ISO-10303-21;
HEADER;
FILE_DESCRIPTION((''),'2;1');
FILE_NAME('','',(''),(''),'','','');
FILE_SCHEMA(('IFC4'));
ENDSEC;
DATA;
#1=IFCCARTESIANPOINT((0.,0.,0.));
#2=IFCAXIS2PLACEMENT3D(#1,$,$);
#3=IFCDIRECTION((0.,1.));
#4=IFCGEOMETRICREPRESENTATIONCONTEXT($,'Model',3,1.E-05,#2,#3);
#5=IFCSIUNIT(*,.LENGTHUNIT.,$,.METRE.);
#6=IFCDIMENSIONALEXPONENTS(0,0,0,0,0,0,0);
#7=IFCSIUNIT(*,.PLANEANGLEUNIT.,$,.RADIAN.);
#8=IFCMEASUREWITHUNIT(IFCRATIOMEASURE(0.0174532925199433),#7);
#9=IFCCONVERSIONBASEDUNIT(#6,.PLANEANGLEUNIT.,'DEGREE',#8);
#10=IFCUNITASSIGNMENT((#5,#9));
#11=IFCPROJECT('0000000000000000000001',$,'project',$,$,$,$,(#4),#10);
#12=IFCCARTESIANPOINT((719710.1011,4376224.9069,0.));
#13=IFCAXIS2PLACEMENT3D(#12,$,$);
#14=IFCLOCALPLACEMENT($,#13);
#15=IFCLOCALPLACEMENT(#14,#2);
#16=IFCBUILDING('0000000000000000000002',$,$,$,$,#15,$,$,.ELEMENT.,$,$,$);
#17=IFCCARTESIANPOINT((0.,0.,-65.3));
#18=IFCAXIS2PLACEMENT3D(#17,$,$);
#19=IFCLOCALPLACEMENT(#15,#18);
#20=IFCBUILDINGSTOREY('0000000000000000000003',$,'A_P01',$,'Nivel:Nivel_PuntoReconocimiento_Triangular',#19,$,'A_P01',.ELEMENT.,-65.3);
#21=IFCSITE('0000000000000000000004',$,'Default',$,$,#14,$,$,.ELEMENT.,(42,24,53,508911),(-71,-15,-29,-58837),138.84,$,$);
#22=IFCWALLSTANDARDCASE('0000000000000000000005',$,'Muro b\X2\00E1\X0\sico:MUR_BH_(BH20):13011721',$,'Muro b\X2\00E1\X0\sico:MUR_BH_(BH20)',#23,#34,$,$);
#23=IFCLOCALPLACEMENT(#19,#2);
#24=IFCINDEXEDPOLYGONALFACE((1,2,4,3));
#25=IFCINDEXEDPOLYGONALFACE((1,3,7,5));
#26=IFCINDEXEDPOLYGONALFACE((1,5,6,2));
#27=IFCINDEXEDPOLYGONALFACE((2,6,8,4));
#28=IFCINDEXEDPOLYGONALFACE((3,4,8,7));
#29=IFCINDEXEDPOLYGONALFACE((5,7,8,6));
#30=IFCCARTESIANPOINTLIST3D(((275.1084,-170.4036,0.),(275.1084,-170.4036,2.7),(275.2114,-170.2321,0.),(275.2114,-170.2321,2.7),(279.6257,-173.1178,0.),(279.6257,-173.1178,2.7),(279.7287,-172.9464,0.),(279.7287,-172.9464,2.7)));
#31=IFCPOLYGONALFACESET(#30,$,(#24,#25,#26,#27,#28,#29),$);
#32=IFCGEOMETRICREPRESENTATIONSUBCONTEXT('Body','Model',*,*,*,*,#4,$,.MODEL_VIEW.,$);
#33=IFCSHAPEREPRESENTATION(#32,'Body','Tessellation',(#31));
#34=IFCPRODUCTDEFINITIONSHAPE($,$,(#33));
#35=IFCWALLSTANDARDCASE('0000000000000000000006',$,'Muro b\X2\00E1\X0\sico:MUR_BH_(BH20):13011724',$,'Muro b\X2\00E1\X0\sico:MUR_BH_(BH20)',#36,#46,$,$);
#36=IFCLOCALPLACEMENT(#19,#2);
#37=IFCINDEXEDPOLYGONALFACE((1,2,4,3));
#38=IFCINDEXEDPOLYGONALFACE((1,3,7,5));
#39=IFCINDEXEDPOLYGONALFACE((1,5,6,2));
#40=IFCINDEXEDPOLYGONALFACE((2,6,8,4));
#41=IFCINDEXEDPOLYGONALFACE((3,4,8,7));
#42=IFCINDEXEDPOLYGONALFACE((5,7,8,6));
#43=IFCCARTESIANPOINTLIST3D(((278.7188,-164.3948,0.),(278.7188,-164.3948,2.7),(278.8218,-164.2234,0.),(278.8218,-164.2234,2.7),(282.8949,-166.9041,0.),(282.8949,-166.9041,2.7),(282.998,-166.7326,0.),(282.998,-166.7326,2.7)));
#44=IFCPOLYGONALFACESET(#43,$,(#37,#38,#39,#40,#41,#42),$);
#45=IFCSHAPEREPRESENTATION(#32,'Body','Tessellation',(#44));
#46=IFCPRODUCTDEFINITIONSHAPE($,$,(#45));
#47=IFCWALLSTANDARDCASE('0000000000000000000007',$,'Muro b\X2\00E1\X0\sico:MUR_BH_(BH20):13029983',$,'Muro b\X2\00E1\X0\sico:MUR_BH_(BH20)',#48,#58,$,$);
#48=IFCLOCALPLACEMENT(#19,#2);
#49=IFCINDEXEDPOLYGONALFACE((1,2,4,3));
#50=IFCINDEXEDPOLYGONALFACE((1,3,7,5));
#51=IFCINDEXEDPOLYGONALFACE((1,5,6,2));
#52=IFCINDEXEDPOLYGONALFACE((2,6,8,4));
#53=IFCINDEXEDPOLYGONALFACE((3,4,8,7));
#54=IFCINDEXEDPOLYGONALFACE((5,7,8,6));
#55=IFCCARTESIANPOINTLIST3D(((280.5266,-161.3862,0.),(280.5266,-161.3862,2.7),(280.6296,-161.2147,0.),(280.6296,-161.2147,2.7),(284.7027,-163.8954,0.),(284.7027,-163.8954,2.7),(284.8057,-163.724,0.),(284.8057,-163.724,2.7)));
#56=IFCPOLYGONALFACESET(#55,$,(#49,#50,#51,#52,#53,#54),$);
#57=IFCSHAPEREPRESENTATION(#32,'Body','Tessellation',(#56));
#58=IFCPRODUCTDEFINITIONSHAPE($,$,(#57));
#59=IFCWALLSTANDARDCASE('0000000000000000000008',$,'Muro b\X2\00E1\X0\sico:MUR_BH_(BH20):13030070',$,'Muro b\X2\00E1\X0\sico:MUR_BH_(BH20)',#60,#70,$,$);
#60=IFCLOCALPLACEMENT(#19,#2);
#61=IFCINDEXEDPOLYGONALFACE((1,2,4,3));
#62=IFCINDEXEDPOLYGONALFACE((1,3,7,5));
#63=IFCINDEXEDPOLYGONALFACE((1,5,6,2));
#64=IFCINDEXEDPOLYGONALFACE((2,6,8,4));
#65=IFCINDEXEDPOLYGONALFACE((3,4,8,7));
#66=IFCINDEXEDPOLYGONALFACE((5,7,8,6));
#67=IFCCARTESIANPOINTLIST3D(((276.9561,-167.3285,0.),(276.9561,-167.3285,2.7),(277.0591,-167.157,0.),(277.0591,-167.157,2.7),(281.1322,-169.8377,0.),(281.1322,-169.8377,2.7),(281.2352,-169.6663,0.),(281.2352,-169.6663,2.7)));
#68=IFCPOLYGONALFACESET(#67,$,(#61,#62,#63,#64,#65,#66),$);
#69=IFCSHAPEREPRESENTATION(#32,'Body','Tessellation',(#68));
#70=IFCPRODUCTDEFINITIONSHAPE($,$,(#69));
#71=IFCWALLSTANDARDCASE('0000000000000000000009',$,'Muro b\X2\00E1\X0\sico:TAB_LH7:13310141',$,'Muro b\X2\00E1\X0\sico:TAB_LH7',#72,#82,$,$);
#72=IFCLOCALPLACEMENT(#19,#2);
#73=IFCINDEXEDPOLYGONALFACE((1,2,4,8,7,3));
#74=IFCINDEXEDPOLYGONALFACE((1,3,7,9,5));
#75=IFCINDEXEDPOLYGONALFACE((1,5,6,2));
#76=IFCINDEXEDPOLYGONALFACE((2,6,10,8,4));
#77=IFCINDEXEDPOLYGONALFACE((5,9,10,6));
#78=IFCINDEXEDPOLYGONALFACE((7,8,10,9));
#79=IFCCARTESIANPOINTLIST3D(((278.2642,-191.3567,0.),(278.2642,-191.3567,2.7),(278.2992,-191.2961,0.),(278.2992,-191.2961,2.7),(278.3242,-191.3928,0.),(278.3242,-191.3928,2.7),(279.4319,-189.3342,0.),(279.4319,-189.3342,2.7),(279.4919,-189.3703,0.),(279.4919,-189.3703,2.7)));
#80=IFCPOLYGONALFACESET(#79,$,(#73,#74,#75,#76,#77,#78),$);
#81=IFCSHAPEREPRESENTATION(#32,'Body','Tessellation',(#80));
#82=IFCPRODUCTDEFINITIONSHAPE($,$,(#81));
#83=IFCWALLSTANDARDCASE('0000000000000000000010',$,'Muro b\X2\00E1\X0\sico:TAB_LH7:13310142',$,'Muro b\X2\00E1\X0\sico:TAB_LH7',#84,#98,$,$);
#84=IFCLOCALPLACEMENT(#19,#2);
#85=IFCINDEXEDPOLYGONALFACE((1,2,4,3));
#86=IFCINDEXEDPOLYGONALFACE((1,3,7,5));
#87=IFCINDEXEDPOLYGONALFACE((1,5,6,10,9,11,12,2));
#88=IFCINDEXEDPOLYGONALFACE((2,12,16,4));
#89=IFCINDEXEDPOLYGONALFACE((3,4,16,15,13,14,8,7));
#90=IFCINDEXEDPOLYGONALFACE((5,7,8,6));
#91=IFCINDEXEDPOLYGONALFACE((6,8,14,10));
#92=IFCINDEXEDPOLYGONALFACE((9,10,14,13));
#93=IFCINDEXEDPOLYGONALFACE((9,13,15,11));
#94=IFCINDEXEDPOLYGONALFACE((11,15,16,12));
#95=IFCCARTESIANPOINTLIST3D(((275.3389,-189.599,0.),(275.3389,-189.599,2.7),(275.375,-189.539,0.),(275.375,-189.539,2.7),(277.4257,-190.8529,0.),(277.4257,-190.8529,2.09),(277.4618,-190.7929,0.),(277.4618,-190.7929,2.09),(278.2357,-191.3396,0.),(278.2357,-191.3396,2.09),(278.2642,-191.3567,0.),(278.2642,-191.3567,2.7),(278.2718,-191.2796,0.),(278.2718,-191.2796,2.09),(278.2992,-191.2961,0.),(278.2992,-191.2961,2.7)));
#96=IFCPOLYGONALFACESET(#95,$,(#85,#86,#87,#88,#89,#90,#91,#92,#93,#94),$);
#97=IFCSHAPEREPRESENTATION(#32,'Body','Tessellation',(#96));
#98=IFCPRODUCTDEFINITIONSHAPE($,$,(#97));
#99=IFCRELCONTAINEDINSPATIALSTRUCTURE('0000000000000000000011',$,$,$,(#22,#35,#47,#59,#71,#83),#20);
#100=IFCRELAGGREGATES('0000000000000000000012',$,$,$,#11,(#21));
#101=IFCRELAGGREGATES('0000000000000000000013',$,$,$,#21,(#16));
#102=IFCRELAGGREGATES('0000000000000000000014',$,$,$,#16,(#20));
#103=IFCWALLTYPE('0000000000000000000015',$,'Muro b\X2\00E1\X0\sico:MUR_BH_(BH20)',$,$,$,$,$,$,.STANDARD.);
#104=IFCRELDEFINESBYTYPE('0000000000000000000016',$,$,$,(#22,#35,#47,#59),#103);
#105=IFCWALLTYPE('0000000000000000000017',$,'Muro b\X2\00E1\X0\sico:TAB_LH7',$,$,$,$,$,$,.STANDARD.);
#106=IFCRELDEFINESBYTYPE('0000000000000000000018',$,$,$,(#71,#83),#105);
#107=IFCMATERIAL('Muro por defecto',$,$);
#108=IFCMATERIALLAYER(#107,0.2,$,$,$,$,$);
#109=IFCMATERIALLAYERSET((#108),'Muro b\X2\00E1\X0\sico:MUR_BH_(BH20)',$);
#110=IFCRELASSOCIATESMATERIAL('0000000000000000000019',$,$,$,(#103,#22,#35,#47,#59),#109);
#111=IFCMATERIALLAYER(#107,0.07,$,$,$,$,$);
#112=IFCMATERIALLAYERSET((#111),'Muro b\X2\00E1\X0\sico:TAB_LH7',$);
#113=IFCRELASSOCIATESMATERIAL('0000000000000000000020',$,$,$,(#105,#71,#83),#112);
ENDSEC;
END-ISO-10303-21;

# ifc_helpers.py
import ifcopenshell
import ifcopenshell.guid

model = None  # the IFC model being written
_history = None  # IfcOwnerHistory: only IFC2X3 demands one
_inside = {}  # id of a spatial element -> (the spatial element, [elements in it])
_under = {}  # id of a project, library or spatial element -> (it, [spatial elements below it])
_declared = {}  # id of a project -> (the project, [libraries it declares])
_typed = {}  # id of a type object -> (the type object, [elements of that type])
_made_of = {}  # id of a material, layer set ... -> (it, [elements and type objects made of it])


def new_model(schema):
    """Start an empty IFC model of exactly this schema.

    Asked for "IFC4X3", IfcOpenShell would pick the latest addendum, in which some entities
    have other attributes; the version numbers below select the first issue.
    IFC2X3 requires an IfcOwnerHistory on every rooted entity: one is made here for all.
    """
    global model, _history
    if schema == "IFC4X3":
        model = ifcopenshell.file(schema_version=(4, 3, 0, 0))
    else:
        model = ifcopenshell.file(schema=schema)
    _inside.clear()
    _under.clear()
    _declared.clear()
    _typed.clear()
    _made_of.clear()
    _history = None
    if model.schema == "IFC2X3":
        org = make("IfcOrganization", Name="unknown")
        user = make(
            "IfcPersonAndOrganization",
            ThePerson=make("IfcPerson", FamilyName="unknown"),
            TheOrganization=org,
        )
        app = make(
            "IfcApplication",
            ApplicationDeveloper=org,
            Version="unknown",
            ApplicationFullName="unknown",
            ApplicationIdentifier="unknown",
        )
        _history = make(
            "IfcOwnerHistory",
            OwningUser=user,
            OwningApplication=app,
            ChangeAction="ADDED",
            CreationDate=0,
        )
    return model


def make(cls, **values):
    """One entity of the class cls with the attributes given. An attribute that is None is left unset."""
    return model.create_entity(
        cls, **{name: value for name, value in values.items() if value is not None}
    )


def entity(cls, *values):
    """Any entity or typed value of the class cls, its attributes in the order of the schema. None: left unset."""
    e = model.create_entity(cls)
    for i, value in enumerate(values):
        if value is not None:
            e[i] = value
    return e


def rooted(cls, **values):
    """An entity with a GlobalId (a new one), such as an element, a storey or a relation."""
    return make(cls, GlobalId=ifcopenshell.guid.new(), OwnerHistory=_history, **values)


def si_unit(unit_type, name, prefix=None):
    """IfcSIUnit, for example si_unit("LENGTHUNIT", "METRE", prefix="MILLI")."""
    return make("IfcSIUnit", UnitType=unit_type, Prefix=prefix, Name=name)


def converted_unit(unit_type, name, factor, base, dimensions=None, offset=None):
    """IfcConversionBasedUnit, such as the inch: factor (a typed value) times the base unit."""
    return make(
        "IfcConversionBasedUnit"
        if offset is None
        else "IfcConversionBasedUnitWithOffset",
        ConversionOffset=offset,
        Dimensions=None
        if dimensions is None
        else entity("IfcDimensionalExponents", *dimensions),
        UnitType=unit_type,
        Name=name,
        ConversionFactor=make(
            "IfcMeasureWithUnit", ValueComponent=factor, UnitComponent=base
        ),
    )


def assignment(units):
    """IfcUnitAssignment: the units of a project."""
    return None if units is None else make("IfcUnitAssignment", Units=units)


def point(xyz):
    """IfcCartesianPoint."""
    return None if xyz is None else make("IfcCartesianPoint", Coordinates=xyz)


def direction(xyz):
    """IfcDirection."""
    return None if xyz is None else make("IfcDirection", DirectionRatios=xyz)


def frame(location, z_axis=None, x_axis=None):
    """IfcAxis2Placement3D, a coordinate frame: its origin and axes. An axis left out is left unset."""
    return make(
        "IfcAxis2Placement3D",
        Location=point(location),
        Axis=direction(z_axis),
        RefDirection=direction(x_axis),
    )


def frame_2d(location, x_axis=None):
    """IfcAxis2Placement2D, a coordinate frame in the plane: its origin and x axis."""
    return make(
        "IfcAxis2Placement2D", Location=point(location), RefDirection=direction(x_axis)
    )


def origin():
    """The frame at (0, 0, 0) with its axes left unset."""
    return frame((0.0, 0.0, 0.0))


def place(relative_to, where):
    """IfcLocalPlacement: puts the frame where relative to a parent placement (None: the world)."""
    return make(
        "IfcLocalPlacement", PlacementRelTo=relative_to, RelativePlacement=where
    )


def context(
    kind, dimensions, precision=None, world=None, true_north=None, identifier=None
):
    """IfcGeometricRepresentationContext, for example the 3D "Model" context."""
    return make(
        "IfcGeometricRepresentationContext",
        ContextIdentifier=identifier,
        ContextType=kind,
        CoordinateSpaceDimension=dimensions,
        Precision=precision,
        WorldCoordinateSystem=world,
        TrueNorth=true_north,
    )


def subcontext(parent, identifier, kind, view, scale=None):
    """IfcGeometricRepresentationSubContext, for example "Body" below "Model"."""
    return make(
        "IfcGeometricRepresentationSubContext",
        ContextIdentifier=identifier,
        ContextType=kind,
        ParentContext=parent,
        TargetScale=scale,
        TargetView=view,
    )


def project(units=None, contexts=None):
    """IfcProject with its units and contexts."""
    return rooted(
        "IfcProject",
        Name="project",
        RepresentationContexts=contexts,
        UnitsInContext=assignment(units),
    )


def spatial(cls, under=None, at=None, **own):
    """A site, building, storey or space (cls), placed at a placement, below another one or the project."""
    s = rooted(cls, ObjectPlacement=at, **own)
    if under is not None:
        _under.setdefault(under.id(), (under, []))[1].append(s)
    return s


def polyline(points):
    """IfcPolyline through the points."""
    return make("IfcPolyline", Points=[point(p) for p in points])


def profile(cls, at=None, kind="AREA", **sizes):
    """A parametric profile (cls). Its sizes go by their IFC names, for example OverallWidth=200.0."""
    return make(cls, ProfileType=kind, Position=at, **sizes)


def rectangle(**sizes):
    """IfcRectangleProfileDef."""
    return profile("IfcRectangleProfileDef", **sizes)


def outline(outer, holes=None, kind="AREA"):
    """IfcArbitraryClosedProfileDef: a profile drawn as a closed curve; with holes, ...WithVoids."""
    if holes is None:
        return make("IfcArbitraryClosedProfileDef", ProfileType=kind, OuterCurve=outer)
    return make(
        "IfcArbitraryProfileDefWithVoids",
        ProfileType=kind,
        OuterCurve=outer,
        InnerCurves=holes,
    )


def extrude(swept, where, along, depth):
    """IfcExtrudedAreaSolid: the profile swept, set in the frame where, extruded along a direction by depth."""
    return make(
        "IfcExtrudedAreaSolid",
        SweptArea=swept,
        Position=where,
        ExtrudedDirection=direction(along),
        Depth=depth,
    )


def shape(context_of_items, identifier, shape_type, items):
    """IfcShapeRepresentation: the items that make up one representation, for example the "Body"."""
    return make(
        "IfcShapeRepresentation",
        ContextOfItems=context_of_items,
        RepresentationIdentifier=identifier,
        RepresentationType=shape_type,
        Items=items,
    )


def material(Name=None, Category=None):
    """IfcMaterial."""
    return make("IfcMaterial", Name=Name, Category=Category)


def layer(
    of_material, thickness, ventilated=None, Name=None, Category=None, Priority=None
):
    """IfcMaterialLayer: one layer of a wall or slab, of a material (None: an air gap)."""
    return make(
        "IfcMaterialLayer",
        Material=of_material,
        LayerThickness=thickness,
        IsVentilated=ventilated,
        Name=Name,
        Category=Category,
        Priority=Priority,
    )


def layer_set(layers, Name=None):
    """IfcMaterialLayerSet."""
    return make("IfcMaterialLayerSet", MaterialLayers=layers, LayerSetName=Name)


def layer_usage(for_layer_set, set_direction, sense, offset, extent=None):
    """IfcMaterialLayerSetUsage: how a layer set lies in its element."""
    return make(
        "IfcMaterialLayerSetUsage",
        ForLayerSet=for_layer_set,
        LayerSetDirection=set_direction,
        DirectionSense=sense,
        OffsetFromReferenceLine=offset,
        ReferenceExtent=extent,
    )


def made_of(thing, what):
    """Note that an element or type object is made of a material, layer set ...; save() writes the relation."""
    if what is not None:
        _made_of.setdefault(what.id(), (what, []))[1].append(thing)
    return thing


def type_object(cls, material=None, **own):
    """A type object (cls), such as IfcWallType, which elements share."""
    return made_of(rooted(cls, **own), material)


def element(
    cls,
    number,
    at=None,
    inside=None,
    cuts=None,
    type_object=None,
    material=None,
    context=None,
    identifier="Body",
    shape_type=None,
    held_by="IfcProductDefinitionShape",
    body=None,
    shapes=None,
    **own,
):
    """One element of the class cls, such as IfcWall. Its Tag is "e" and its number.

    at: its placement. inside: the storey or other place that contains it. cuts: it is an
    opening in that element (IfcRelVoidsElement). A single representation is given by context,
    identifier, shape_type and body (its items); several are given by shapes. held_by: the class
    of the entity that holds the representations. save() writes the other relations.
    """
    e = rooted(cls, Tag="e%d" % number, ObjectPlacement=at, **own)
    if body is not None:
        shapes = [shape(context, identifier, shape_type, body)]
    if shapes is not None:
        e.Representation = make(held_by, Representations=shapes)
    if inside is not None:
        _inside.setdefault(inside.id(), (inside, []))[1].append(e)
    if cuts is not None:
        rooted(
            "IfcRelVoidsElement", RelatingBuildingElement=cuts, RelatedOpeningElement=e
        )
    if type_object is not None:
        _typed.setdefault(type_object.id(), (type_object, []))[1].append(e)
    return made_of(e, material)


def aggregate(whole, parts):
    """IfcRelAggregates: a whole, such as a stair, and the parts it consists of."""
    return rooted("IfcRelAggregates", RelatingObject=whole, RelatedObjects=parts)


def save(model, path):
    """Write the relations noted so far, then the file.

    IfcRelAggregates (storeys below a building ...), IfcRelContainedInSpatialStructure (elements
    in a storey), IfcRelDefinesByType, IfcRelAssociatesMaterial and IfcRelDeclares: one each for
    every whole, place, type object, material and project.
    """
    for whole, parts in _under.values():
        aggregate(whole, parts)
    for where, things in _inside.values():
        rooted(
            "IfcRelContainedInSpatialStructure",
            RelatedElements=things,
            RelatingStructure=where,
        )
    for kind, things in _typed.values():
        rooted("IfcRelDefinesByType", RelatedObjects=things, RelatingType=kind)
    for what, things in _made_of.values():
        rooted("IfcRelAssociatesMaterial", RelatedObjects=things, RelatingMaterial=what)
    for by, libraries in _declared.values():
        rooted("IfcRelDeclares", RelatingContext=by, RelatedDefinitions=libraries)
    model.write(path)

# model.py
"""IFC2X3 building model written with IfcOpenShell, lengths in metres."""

from ifc_helpers import new_model, entity, si_unit, converted_unit, direction, frame, frame_2d, origin, place, context, subcontext, project, spatial, polyline, rectangle, outline, extrude, material, layer, layer_set, layer_usage, type_object, element, save


model = new_model("IFC2X3")

# Units and contexts
model_context = context("Model", 3, precision=1e-05, world=origin(), true_north=direction((0.0, 1.0)))
body_context = subcontext(model_context, "Body", "Model", "MODEL_VIEW")
ifc_project = project(units=[si_unit("LENGTHUNIT", "METRE"), converted_unit("PLANEANGLEUNIT", "DEGREE", entity("IfcRatioMeasure", 0.0174532925199433), si_unit("PLANEANGLEUNIT", "RADIAN"), dimensions=[0, 0, 0, 0, 0, 0, 0])], contexts=[model_context])

# Site, building, storey
site_placement = place(None, frame((719710.1011, 4376224.9069, 0.0)))
site = spatial("IfcSite", under=ifc_project, at=site_placement, Name="Default", CompositionType="ELEMENT", RefLatitude=(42, 24, 53, 508911), RefLongitude=(-71, -15, -29, -58837), RefElevation=138.84)
building_placement = place(site_placement, origin())
building = spatial("IfcBuilding", under=site, at=building_placement, CompositionType="ELEMENT")
storey_placement = place(building_placement, frame((0.0, 0.0, -65.3)))
storey = spatial("IfcBuildingStorey", under=building, at=storey_placement, Name="A_P01", ObjectType="Nivel:Nivel_PuntoReconocimiento_Triangular", LongName="A_P01", CompositionType="ELEMENT", Elevation=-65.3)

# Walls
ifc_material_1 = material(Name="Muro por defecto")
ifc_layer_1 = layer(ifc_material_1, 0.2)
ifc_layer_set_1 = layer_set([ifc_layer_1], Name="Muro básico:MUR_BH_(BH20)")
wall_type_1 = type_object("IfcWallType", Name="Muro básico:MUR_BH_(BH20)", PredefinedType="STANDARD", material=ifc_layer_set_1)
ifc_layer_usage_1 = layer_usage(ifc_layer_set_1, "AXIS2", "NEGATIVE", 0.1)
wall_1_placement = place(storey_placement, frame((279.6772, -173.0321, 0.0), z_axis=(0.0, 0.0, 1.0), x_axis=(-0.857167, 0.515038, 0.0)))
element("IfcWallStandardCase", 1, at=wall_1_placement, inside=storey, type_object=wall_type_1, material=ifc_layer_usage_1, Name="Muro básico:MUR_BH_(BH20):13011721", ObjectType="Muro básico:MUR_BH_(BH20)", context=body_context, shape_type="SweptSolid", body=[
    extrude(rectangle(XDim=5.27, YDim=0.2, at=frame_2d((2.635, 0.0), x_axis=(-1.0, 0.0))), origin(), (0.0, 0.0, 1.0), 2.7),
])
ifc_layer_usage_2 = layer_usage(ifc_layer_set_1, "AXIS2", "NEGATIVE", 0.1)
wall_2_placement = place(storey_placement, frame((282.9464, -166.8184, 0.0), z_axis=(0.0, 0.0, 1.0), x_axis=(-0.857167, 0.515038, 0.0)))
element("IfcWallStandardCase", 2, at=wall_2_placement, inside=storey, type_object=wall_type_1, material=ifc_layer_usage_2, Name="Muro básico:MUR_BH_(BH20):13011724", ObjectType="Muro básico:MUR_BH_(BH20)", context=body_context, shape_type="SweptSolid", body=[
    extrude(rectangle(XDim=4.872, YDim=0.2, at=frame_2d((2.436, 0.0), x_axis=(-1.0, 0.0))), origin(), (0.0, 0.0, 1.0), 2.7),
])
ifc_layer_usage_3 = layer_usage(ifc_layer_set_1, "AXIS2", "NEGATIVE", 0.1)
wall_3_placement = place(storey_placement, frame((284.7542, -163.8097, 0.0), z_axis=(0.0, 0.0, 1.0), x_axis=(-0.857167, 0.515038, 0.0)))
element("IfcWallStandardCase", 3, at=wall_3_placement, inside=storey, type_object=wall_type_1, material=ifc_layer_usage_3, Name="Muro básico:MUR_BH_(BH20):13029983", ObjectType="Muro básico:MUR_BH_(BH20)", context=body_context, shape_type="SweptSolid", body=[
    extrude(rectangle(XDim=4.872, YDim=0.2, at=frame_2d((2.436, 0.0), x_axis=(-1.0, 0.0))), origin(), (0.0, 0.0, 1.0), 2.7),
])
ifc_layer_usage_4 = layer_usage(ifc_layer_set_1, "AXIS2", "NEGATIVE", 0.1)
wall_4_placement = place(storey_placement, frame((281.1837, -169.752, 0.0), z_axis=(0.0, 0.0, 1.0), x_axis=(-0.857167, 0.515038, 0.0)))
element("IfcWallStandardCase", 4, at=wall_4_placement, inside=storey, type_object=wall_type_1, material=ifc_layer_usage_4, Name="Muro básico:MUR_BH_(BH20):13030070", ObjectType="Muro básico:MUR_BH_(BH20)", context=body_context, shape_type="SweptSolid", body=[
    extrude(rectangle(XDim=4.872, YDim=0.2, at=frame_2d((2.436, 0.0), x_axis=(-1.0, 0.0))), origin(), (0.0, 0.0, 1.0), 2.7),
])
ifc_layer_2 = layer(ifc_material_1, 0.07)
ifc_layer_set_2 = layer_set([ifc_layer_2], Name="Muro básico:TAB_LH7")
ifc_layer_usage_5 = layer_usage(ifc_layer_set_2, "AXIS2", "NEGATIVE", 0.035)
wall_type_2 = type_object("IfcWallType", Name="Muro básico:TAB_LH7", PredefinedType="STANDARD", material=ifc_layer_set_2)
wall_5_placement = place(storey_placement, frame((279.4622, -189.3517, 0.0), z_axis=(0.0, 0.0, 1.0), x_axis=(-0.5, -0.866025, 0.0)))
element("IfcWallStandardCase", 5, at=wall_5_placement, inside=storey, type_object=wall_type_2, material=ifc_layer_usage_5, Name="Muro básico:TAB_LH7:13310141", ObjectType="Muro básico:TAB_LH7", context=body_context, shape_type="SweptSolid", body=[
    extrude(outline(polyline([(2.3354, -0.035), (2.3366, 0.035), (0.0012, 0.035), (0.0, -0.035), (2.2653, -0.035), (2.3354, -0.035)])), origin(), (0.0, 0.0, 1.0), 2.7),
])

# Wall, opening
ifc_layer_usage_6 = layer_usage(ifc_layer_set_2, "AXIS2", "NEGATIVE", 0.035)
wall_6_placement = place(storey_placement, frame((278.2823, -191.3267, 0.0), z_axis=(0.0, 0.0, 1.0), x_axis=(-0.857167, 0.515038, 0.0)))
wall_6 = element("IfcWallStandardCase", 6, at=wall_6_placement, inside=storey, type_object=wall_type_2, material=ifc_layer_usage_6, Name="Muro básico:TAB_LH7:13310142", ObjectType="Muro básico:TAB_LH7", context=body_context, shape_type="SweptSolid", body=[
    extrude(outline(polyline([(0.0012, -0.035), (3.4127, -0.035), (3.4127, 0.035), (1.1122, 0.035), (1.0422, 0.035), (0.0, 0.035), (0.0012, -0.035)])), origin(), (0.0, 0.0, 1.0), 2.7),
])
opening_placement = place(wall_6_placement, frame((337.075, -20.673, 0.0), z_axis=(0.0, 0.0, 1.0), x_axis=(-0.857167, -0.515038, 0.0)))
element("IfcOpeningElement", 7, at=opening_placement, cuts=wall_6, ObjectType="Opening", context=body_context, shape_type="SweptSolid", body=[
    extrude(rectangle(XDim=2.09, YDim=0.945, at=frame_2d((0.0, 0.0), x_axis=(0.0, 1.0))), frame((277.8668, -191.0362, 1.045), z_axis=(-0.515038, -0.857167, 0.0), x_axis=(-0.857167, 0.515038, 0.0)), (0.0, 0.0, 1.0), 0.07),
])

save(model, "model.ifc")
